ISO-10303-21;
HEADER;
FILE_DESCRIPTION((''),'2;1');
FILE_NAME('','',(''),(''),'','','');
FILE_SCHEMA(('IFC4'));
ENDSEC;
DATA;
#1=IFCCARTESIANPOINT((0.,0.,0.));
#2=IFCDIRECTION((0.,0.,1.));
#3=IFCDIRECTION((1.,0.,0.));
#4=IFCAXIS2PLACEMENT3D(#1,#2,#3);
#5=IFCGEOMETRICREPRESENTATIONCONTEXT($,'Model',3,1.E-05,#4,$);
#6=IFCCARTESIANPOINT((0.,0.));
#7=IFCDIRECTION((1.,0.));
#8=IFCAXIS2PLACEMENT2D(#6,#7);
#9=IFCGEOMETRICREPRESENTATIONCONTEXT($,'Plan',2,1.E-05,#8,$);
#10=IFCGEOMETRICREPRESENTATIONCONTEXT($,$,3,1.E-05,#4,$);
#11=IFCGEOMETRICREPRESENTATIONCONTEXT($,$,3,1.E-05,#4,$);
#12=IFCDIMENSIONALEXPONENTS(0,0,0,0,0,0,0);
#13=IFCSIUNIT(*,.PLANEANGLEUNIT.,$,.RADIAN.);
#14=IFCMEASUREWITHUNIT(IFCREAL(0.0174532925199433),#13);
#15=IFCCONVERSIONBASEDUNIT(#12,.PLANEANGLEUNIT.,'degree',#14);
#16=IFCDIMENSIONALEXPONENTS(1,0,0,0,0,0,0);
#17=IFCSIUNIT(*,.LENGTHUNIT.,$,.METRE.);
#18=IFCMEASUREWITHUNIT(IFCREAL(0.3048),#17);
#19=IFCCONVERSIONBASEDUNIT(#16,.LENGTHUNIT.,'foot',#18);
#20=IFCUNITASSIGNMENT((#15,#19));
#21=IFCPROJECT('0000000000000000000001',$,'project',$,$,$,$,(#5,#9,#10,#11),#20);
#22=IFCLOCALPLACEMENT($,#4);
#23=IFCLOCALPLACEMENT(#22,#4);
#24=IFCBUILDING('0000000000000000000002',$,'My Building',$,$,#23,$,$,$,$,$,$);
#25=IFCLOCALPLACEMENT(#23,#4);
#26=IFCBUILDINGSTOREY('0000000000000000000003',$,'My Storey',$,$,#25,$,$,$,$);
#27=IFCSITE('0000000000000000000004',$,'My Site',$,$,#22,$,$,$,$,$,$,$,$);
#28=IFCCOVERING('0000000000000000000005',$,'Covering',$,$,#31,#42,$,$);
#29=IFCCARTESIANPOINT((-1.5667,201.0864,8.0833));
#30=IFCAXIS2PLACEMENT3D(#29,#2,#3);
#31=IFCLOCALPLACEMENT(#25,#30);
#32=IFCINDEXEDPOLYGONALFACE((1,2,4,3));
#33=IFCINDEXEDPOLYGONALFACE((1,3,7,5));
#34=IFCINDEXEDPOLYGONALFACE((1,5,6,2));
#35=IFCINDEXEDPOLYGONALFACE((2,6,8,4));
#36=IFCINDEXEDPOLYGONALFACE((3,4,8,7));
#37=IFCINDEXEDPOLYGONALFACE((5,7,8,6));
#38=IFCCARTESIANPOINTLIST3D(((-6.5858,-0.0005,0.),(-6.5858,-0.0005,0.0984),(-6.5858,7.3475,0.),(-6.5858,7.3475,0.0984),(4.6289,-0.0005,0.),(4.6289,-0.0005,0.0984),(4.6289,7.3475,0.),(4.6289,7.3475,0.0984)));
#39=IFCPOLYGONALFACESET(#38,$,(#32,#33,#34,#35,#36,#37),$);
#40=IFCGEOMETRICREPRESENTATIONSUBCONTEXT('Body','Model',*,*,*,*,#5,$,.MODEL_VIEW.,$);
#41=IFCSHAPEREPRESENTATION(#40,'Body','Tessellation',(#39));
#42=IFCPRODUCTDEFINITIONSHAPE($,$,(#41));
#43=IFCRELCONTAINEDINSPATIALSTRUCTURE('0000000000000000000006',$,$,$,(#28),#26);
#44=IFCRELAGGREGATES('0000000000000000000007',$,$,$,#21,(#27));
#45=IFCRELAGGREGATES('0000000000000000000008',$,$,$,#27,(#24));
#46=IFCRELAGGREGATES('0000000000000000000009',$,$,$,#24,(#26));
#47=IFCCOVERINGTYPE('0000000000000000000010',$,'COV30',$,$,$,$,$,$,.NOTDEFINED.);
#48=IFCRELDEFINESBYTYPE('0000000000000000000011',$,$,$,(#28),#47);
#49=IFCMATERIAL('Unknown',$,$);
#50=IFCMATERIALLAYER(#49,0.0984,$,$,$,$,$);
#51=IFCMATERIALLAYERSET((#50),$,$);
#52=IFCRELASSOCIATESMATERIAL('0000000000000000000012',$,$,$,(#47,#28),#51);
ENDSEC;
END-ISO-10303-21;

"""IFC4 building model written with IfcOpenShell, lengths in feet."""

from ifc_helpers import new_model, entity, si_unit, converted_unit, frame, origin_with_axes, origin_2d_with_axis, place, context, subcontext, project, spatial, line, indexed_curve, outline, extrude, material, layer, layer_set, layer_usage, type_object, element, save


model = new_model("IFC4")

# Units and contexts
model_context = context("Model", 3, precision=1e-05, world=origin_with_axes())
plan_context = context("Plan", 2, precision=1e-05, world=origin_2d_with_axis())
context_of_model_1 = context(None, 3, precision=1e-05, world=origin_with_axes())
context_of_model_2 = context(None, 3, precision=1e-05, world=origin_with_axes())
body_context_1 = subcontext(model_context, "Body", "Model", "MODEL_VIEW")
ifc_project = project(units=[converted_unit("PLANEANGLEUNIT", "degree", entity("IfcReal", 0.0174532925199433), si_unit("PLANEANGLEUNIT", "RADIAN"), dimensions=[0, 0, 0, 0, 0, 0, 0]), converted_unit("LENGTHUNIT", "foot", entity("IfcReal", 0.3048), si_unit("LENGTHUNIT", "METRE"), dimensions=[1, 0, 0, 0, 0, 0, 0])], contexts=[model_context, plan_context, context_of_model_1, context_of_model_2])

# Site, building, storey
site_placement = place(None, origin_with_axes())
site = spatial("IfcSite", under=ifc_project, at=site_placement, Name="My Site")
building_placement = place(site_placement, origin_with_axes())
building = spatial("IfcBuilding", under=site, at=building_placement, Name="My Building")
storey_placement = place(building_placement, origin_with_axes())
storey = spatial("IfcBuildingStorey", under=building, at=storey_placement, Name="My Storey")

# Covering
ifc_material_1 = material(Name="Unknown")
ifc_layer_1 = layer(ifc_material_1, 0.0984)
ifc_layer_set_1 = layer_set([ifc_layer_1])
ifc_layer_usage_1 = layer_usage(ifc_layer_set_1, "AXIS3", "POSITIVE", 0.0)
covering_type = type_object("IfcCoveringType", Name="COV30", PredefinedType="NOTDEFINED", material=ifc_layer_set_1)
covering_placement = place(storey_placement, frame((-1.5667, 201.0864, 8.0833), z_axis=(0.0, 0.0, 1.0), x_axis=(1.0, 0.0, 0.0)))
element("IfcCovering", 1, at=covering_placement, inside=storey, type_object=covering_type, material=ifc_layer_usage_1, Name="Covering", context=body_context_1, shape_type="SweptSolid", body=[
    extrude(outline(indexed_curve([(4.6289, -0.0005), (4.6289, 7.3475), (-6.5858, 7.3475), (-6.5858, -0.0005)], segments=[line(4, 1), line(1, 2), line(2, 3), line(3, 4)], self_intersect=False)), None, (0.0, 0.0, 1.0), 0.0984),
])

save(model, "model.ifc")
